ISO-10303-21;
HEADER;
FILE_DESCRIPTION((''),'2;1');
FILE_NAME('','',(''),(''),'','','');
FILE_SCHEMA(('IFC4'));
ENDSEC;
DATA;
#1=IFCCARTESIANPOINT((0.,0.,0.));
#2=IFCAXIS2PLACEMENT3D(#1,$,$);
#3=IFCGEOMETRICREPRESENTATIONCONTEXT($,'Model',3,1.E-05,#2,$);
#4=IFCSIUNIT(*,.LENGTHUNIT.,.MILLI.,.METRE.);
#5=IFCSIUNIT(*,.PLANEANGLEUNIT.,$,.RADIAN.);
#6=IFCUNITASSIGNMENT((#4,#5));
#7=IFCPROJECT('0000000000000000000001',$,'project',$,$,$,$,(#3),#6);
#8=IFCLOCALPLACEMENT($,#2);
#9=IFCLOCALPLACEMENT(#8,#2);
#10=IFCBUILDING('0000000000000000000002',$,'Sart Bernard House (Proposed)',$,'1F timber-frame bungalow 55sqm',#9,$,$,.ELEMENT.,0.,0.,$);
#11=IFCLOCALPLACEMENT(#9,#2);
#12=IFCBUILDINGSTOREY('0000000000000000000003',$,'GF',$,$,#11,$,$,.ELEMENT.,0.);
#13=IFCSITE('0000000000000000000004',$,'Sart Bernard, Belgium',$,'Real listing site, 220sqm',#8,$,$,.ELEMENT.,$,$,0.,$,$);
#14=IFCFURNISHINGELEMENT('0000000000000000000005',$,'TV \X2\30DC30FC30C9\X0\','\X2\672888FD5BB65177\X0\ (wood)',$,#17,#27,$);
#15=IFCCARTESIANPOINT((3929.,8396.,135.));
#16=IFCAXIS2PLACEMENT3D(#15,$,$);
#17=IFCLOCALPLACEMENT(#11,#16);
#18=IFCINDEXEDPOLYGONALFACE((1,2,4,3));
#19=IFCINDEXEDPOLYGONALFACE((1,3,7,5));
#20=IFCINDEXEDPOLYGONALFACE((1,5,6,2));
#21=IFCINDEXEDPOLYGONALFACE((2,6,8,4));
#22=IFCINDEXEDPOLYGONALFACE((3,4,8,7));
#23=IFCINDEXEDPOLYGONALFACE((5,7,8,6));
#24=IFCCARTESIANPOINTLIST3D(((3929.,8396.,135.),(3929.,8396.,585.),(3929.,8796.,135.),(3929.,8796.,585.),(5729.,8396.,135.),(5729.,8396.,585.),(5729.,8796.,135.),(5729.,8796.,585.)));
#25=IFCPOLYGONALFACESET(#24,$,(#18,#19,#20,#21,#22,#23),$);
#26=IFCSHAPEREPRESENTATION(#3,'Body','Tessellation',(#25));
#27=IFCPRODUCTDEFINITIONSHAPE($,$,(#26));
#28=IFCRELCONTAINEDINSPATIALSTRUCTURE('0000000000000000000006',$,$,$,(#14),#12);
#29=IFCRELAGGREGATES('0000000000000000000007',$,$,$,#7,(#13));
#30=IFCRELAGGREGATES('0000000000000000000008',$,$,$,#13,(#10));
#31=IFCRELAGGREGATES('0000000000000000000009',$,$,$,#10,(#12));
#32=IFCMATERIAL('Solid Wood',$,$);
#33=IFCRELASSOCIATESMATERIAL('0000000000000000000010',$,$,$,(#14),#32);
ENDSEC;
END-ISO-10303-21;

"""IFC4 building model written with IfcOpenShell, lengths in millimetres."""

from ifc_helpers import new_model, si_unit, frame, frame_2d, origin, place, context, project, spatial, rectangle, extrude, material, element, save


model = new_model("IFC4")

# Units and contexts
model_context = context("Model", 3, precision=1e-05, world=origin())
ifc_project = project(units=[si_unit("LENGTHUNIT", "METRE", prefix="MILLI"), si_unit("PLANEANGLEUNIT", "RADIAN")], contexts=[model_context])

# Site, building, storey
site_placement = place(None, origin())
site = spatial("IfcSite", under=ifc_project, at=site_placement, Name="Sart Bernard, Belgium", ObjectType="Real listing site, 220sqm", CompositionType="ELEMENT", RefElevation=0.0)
building_placement = place(site_placement, origin())
building = spatial("IfcBuilding", under=site, at=building_placement, Name="Sart Bernard House (Proposed)", ObjectType="1F timber-frame bungalow 55sqm", CompositionType="ELEMENT", ElevationOfRefHeight=0.0, ElevationOfTerrain=0.0)
storey_placement = place(building_placement, origin())
storey = spatial("IfcBuildingStorey", under=building, at=storey_placement, Name="GF", CompositionType="ELEMENT", Elevation=0.0)

# Shared definitions
ifc_material_1 = material(Name="Solid Wood")

# Furnishing element
furnishing_placement = place(storey_placement, frame((3929.0, 8396.0, 135.0)))
element("IfcFurnishingElement", 1, at=furnishing_placement, inside=storey, material=ifc_material_1, Name="TV ボード", Description="木製家具 (wood)", context=model_context, shape_type="SweptSolid", body=[
    extrude(rectangle(XDim=1800.0, YDim=400.0, at=frame_2d((900.0, 200.0))), frame((3929.0, 8396.0, 135.0)), (0.0, 0.0, 1.0), 450.0),
])

save(model, "model.ifc")
